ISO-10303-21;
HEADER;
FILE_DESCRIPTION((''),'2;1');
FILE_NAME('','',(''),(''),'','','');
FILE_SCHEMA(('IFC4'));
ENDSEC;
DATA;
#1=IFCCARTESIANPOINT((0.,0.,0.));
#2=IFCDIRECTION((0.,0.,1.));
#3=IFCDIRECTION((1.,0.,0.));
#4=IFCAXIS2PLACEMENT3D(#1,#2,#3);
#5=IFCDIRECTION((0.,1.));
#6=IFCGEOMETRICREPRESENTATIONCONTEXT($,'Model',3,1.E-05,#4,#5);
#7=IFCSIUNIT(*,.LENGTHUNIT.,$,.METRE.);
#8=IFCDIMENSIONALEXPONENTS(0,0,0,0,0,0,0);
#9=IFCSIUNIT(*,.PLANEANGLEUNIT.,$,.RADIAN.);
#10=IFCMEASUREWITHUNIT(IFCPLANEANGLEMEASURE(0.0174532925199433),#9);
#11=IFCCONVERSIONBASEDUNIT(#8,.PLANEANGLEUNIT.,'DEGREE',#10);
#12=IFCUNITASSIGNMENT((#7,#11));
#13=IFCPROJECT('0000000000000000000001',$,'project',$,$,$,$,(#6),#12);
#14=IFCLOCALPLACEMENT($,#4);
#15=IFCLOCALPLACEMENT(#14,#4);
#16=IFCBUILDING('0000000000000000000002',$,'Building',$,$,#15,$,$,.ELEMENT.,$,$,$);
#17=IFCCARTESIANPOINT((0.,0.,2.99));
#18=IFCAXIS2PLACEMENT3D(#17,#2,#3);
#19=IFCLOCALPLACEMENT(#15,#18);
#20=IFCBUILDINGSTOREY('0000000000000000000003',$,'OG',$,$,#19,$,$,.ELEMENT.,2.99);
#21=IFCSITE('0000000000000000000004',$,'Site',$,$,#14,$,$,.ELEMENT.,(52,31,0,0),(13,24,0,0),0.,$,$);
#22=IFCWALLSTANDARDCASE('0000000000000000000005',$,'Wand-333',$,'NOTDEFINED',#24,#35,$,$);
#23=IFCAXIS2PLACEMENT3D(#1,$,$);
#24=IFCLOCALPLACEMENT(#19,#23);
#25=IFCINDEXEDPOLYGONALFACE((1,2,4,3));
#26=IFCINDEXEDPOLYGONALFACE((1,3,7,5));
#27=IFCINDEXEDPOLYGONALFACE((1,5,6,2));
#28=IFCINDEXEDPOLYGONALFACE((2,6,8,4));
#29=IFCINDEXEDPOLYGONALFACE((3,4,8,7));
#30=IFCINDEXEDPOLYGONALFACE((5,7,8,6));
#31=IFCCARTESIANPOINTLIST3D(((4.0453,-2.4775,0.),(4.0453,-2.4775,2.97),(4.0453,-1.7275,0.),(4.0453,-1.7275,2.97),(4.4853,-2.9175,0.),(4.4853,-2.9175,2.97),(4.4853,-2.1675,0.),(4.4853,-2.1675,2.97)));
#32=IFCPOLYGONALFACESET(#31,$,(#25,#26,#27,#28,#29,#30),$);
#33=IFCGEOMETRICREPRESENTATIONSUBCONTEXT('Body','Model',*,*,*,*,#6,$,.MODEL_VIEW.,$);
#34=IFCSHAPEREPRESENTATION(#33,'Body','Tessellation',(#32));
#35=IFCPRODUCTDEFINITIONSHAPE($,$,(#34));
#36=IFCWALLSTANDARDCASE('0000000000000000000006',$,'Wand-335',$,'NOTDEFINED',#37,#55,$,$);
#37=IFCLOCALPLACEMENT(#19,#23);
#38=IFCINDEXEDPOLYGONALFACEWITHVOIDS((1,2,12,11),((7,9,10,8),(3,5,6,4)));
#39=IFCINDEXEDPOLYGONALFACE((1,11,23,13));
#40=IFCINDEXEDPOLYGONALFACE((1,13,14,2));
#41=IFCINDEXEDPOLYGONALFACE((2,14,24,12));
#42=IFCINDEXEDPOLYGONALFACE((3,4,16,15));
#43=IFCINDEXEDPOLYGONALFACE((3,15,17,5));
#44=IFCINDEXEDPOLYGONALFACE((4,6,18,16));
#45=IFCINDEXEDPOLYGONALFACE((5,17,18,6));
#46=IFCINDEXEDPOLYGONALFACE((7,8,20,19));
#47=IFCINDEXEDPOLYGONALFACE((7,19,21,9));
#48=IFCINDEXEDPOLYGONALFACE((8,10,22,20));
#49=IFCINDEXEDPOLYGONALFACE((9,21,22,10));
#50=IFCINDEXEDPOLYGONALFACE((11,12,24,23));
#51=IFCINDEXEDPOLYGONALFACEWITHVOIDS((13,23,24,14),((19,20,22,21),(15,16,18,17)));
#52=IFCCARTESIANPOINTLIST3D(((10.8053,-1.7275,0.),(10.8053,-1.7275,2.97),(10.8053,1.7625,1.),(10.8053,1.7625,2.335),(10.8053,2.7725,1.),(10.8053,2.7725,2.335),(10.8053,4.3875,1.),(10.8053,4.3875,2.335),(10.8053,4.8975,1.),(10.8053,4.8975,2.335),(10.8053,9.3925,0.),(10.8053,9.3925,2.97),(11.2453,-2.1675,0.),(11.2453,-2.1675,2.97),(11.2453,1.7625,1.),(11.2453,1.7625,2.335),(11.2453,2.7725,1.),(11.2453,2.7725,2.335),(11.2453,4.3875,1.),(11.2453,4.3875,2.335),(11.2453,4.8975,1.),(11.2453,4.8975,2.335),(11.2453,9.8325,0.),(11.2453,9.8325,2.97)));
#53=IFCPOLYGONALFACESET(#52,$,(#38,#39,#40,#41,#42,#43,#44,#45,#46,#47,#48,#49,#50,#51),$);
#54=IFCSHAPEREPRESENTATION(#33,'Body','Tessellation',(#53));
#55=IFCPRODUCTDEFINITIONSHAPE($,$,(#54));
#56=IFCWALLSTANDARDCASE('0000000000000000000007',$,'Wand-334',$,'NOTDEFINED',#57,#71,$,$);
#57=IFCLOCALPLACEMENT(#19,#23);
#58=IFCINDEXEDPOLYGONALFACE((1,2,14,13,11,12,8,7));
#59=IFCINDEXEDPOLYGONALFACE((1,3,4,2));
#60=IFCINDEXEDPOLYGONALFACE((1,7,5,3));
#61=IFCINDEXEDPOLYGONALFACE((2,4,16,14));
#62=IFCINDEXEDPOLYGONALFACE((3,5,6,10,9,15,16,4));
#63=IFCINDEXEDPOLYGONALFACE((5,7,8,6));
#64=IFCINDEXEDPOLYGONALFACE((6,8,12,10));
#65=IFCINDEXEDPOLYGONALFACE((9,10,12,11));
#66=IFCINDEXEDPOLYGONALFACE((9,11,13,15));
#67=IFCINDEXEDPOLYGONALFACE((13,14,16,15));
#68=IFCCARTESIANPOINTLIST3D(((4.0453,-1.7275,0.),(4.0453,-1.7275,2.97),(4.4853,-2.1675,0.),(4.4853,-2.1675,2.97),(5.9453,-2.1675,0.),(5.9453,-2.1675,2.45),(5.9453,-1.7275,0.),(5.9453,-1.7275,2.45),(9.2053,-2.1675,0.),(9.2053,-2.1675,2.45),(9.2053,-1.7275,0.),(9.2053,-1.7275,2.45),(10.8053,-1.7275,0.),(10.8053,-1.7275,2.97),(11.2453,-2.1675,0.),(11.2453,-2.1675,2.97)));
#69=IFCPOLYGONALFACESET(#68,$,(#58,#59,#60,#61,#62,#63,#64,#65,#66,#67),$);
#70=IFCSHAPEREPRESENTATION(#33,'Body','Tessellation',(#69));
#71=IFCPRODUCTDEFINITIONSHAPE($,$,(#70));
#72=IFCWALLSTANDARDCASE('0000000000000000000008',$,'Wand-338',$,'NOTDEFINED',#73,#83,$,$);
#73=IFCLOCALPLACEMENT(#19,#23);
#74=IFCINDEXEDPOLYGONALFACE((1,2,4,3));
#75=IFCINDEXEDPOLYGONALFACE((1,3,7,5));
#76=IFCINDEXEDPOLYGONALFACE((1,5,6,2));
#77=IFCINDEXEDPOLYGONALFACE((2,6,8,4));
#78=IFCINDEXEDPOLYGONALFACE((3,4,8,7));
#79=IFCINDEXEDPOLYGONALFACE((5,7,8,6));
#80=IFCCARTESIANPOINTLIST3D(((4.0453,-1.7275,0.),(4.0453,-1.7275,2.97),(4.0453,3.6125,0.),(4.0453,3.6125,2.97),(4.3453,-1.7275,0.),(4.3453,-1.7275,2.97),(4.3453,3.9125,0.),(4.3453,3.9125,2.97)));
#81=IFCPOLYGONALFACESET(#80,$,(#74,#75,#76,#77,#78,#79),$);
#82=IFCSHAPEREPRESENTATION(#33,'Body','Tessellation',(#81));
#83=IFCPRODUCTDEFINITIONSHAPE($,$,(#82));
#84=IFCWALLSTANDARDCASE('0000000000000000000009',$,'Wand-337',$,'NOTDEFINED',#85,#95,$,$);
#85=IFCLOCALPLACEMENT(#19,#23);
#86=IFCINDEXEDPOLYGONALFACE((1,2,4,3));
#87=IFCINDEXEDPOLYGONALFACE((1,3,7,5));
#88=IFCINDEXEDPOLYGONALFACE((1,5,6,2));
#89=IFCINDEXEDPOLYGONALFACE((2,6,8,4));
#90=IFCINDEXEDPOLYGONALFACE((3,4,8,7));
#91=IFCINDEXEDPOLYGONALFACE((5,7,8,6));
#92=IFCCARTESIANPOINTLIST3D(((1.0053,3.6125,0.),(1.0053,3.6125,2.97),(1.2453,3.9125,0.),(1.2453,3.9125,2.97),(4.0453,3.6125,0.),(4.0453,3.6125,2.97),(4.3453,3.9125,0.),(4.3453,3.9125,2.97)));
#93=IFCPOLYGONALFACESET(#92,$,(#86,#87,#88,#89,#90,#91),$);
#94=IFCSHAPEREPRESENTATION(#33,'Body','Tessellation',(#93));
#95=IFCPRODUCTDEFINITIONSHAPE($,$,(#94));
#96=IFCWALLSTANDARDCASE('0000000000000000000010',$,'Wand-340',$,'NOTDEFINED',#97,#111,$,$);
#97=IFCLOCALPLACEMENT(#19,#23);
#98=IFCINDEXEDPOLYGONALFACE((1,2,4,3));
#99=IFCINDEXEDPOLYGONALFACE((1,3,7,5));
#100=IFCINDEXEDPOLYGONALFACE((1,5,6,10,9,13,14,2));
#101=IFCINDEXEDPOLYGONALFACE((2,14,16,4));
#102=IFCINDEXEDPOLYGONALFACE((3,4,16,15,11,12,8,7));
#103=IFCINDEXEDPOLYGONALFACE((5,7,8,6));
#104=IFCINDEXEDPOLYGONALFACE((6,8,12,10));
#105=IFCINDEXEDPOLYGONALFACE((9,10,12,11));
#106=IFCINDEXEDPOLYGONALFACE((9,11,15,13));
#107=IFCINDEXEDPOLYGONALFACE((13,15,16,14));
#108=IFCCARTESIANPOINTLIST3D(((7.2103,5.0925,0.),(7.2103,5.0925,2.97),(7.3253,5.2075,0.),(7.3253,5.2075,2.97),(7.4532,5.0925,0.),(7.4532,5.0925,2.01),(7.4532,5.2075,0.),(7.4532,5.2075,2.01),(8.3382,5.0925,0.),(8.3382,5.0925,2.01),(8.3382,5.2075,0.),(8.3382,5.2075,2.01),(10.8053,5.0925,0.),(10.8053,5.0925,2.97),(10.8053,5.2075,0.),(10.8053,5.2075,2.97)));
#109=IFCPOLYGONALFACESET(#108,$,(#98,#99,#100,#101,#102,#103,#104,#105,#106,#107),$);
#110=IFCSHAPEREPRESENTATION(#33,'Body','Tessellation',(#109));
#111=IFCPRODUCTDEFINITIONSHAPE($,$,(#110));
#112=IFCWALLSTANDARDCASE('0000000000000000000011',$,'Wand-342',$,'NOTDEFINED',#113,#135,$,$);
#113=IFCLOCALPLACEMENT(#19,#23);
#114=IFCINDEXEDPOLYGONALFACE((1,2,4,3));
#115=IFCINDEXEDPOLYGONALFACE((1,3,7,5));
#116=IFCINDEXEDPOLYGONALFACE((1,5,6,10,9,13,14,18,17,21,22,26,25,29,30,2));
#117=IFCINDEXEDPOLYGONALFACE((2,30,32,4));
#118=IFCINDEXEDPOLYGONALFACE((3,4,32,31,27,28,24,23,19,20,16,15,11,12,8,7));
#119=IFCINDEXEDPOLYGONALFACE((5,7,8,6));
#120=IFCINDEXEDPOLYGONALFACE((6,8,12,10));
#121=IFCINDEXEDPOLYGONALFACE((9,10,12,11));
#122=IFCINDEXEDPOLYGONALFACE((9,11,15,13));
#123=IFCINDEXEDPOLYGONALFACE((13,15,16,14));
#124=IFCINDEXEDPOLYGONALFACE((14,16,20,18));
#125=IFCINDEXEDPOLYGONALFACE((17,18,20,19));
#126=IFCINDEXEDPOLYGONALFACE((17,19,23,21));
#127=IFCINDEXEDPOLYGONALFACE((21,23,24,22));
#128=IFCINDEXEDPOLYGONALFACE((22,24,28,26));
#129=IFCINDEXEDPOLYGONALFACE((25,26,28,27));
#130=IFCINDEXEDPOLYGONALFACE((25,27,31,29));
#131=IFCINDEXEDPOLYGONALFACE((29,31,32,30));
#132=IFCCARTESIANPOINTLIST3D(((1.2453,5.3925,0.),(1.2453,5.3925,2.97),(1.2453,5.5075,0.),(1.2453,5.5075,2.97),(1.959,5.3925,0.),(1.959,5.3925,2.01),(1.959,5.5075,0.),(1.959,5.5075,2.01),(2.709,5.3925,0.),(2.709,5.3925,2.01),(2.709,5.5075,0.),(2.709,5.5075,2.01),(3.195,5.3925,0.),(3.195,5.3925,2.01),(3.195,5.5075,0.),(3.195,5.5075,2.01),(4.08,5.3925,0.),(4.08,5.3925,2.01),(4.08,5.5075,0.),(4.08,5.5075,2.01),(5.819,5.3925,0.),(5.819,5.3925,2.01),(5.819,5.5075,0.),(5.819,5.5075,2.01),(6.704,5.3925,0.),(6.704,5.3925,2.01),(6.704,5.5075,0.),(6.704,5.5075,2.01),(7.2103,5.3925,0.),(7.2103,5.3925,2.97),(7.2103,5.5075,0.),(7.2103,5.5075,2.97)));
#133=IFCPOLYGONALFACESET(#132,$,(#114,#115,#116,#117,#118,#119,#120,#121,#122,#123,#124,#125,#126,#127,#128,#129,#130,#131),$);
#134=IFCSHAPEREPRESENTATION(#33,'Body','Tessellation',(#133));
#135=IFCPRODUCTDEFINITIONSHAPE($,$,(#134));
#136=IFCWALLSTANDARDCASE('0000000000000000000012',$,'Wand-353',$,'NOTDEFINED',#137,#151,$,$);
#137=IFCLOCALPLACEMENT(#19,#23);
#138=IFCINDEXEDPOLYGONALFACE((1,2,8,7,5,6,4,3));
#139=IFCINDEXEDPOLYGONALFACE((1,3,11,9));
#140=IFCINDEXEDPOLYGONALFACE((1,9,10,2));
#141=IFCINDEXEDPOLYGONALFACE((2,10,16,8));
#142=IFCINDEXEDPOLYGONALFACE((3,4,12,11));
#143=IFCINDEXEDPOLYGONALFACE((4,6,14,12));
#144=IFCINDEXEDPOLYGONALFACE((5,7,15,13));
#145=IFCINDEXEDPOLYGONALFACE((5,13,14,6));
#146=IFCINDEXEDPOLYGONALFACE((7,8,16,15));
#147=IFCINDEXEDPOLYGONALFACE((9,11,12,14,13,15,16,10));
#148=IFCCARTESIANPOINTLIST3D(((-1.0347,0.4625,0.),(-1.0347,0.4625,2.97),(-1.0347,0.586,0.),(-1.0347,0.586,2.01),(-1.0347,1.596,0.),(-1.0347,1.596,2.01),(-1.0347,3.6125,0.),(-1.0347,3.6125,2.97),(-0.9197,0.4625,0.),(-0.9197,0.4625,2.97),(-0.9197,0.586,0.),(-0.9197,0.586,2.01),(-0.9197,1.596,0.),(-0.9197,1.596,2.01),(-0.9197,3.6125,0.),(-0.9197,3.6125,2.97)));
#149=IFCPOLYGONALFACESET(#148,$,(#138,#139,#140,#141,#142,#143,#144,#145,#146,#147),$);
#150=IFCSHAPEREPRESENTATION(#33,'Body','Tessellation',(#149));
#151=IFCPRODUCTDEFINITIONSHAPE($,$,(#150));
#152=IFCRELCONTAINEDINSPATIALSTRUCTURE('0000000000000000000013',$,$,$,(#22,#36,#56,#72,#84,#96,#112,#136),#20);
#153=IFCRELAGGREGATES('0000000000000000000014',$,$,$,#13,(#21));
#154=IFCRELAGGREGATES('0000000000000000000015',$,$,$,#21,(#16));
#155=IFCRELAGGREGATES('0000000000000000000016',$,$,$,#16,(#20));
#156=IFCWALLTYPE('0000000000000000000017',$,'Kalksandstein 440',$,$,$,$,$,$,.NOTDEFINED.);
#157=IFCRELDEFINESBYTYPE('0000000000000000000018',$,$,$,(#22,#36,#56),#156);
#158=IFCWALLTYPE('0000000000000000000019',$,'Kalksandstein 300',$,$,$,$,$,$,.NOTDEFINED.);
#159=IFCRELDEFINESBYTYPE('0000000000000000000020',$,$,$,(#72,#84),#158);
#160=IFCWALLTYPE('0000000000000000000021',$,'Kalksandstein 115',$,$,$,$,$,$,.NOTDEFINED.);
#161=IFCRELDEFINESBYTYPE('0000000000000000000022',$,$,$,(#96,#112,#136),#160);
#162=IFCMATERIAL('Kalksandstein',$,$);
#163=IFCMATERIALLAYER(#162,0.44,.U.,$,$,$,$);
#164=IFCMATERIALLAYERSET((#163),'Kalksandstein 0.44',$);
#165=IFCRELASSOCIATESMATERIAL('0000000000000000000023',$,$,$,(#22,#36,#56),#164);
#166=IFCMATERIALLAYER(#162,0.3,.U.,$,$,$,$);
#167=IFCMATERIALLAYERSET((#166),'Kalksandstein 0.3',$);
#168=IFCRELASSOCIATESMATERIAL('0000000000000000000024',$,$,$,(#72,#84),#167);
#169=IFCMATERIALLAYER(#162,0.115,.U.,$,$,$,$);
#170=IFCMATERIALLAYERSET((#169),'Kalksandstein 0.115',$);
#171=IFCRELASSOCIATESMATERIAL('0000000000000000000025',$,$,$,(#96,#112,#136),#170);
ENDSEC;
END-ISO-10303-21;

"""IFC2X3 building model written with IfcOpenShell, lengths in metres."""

from ifc_helpers import new_model, entity, si_unit, converted_unit, direction, frame, origin_with_axes, origin_2d_with_axis, place, context, subcontext, project, spatial, polyline, rectangle, outline, extrude, material, layer, layer_set, layer_usage, type_object, element, save


model = new_model("IFC2X3")

# Units and contexts
model_context = context("Model", 3, precision=1e-05, world=origin_with_axes(), true_north=direction((0.0, 1.0)))
body_context = subcontext(model_context, "Body", "Model", "MODEL_VIEW")
ifc_project = project(units=[si_unit("LENGTHUNIT", "METRE"), converted_unit("PLANEANGLEUNIT", "DEGREE", entity("IfcPlaneAngleMeasure", 0.0174532925199433), si_unit("PLANEANGLEUNIT", "RADIAN"), dimensions=[0, 0, 0, 0, 0, 0, 0])], contexts=[model_context])

# Site, building, storey
site_placement = place(None, origin_with_axes())
site = spatial("IfcSite", under=ifc_project, at=site_placement, Name="Site", CompositionType="ELEMENT", RefLatitude=(52, 31, 0, 0), RefLongitude=(13, 24, 0, 0), RefElevation=0.0)
building_placement = place(site_placement, origin_with_axes())
building = spatial("IfcBuilding", under=site, at=building_placement, Name="Building", CompositionType="ELEMENT")
storey_placement = place(building_placement, frame((0.0, 0.0, 2.99), z_axis=(0.0, 0.0, 1.0), x_axis=(1.0, 0.0, 0.0)))
storey = spatial("IfcBuildingStorey", under=building, at=storey_placement, Name="OG", CompositionType="ELEMENT", Elevation=2.99)

# Shared definitions
ifc_material = material(Name="Kalksandstein")
ifc_layer_1 = layer(ifc_material, 0.44, ventilated="UNKNOWN")
ifc_layer_set_1 = layer_set([ifc_layer_1], Name="Kalksandstein 0.44")
wall_type_1 = type_object("IfcWallType", Name="Kalksandstein 440", PredefinedType="NOTDEFINED")

# Wall
ifc_layer_usage_1 = layer_usage(ifc_layer_set_1, "AXIS2", "NEGATIVE", 0.44)
wall_1_placement = place(storey_placement, frame((4.4853, -2.9175, 0.0), z_axis=(0.0, 0.0, 1.0), x_axis=(0.0, 1.0, 0.0)))
element("IfcWallStandardCase", 1, at=wall_1_placement, inside=storey, type_object=wall_type_1, material=ifc_layer_usage_1, Name="Wand-333", ObjectType="NOTDEFINED", context=body_context, shape_type="SweptSolid", body=[
    extrude(outline(polyline([(0.0, 0.0), (0.75, 0.0), (1.19, 0.44), (0.44, 0.44), (0.0, 0.0)])), origin_with_axes(), (0.0, 0.0, 1.0), 2.97),
])

# Wall, openings
ifc_layer_usage_2 = layer_usage(ifc_layer_set_1, "AXIS2", "NEGATIVE", 0.44)
wall_2_placement = place(storey_placement, frame((11.2453, -2.1675, 0.0), z_axis=(0.0, 0.0, 1.0), x_axis=(0.0, 1.0, 0.0)))
wall_2 = element("IfcWallStandardCase", 2, at=wall_2_placement, inside=storey, type_object=wall_type_1, material=ifc_layer_usage_2, Name="Wand-335", ObjectType="NOTDEFINED", context=body_context, shape_type="SweptSolid", body=[
    extrude(outline(polyline([(0.0, 0.0), (12.0, 0.0), (11.56, 0.44), (0.44, 0.44), (0.0, 0.0)])), origin_with_axes(), (0.0, 0.0, 1.0), 2.97),
])
opening_1_placement = place(wall_2_placement, frame((4.435, 0.0, 1.0), z_axis=(0.0, 0.0, 1.0), x_axis=(1.0, 0.0, 0.0)))
element("IfcOpeningElement", 3, at=opening_1_placement, cuts=wall_2, context=body_context, shape_type="SweptSolid", body=[
    extrude(rectangle(XDim=1.01, YDim=1.335, at=origin_2d_with_axis()), frame((0.0, 0.44, 0.6675), z_axis=(0.0, -1.0, 0.0), x_axis=(-1.0, 0.0, 0.0)), (0.0, 0.0, 1.0), 1.32),
])
opening_2_placement = place(wall_2_placement, frame((6.81, 0.0, 1.0), z_axis=(0.0, 0.0, 1.0), x_axis=(1.0, 0.0, 0.0)))
element("IfcOpeningElement", 4, at=opening_2_placement, cuts=wall_2, context=body_context, shape_type="SweptSolid", body=[
    extrude(rectangle(XDim=0.51, YDim=1.335, at=origin_2d_with_axis()), frame((0.0, 0.44, 0.6675), z_axis=(0.0, -1.0, 0.0), x_axis=(-1.0, 0.0, 0.0)), (0.0, 0.0, 1.0), 1.32),
])

# Wall, opening
ifc_layer_usage_3 = layer_usage(ifc_layer_set_1, "AXIS2", "NEGATIVE", 0.44)
wall_3_placement = place(storey_placement, frame((4.4853, -2.1675, 0.0), z_axis=(0.0, 0.0, 1.0), x_axis=(1.0, 0.0, 0.0)))
wall_3 = element("IfcWallStandardCase", 5, at=wall_3_placement, inside=storey, type_object=wall_type_1, material=ifc_layer_usage_3, Name="Wand-334", ObjectType="NOTDEFINED", context=body_context, shape_type="SweptSolid", body=[
    extrude(outline(polyline([(0.0, 0.0), (6.76, 0.0), (6.32, 0.44), (-0.44, 0.44), (0.0, 0.0)])), origin_with_axes(), (0.0, 0.0, 1.0), 2.97),
])
opening_3_placement = place(wall_3_placement, frame((3.09, 0.0, 0.0), z_axis=(0.0, 0.0, 1.0), x_axis=(1.0, 0.0, 0.0)))
element("IfcOpeningElement", 6, at=opening_3_placement, cuts=wall_3, context=body_context, shape_type="SweptSolid", body=[
    extrude(rectangle(XDim=3.26, YDim=2.45, at=origin_2d_with_axis()), frame((0.0, 0.44, 1.225), z_axis=(0.0, -1.0, 0.0), x_axis=(-1.0, 0.0, 0.0)), (0.0, 0.0, 1.0), 1.32),
])

# Walls
ifc_layer_2 = layer(ifc_material, 0.3, ventilated="UNKNOWN")
ifc_layer_set_2 = layer_set([ifc_layer_2], Name="Kalksandstein 0.3")
ifc_layer_usage_4 = layer_usage(ifc_layer_set_2, "AXIS2", "NEGATIVE", 0.3)
wall_type_2 = type_object("IfcWallType", Name="Kalksandstein 300", PredefinedType="NOTDEFINED")
wall_4_placement = place(storey_placement, frame((4.0453, 3.6125, 0.0), z_axis=(0.0, 0.0, 1.0), x_axis=(0.0, -1.0, 0.0)))
element("IfcWallStandardCase", 7, at=wall_4_placement, inside=storey, type_object=wall_type_2, material=ifc_layer_usage_4, Name="Wand-338", ObjectType="NOTDEFINED", context=body_context, shape_type="SweptSolid", body=[
    extrude(outline(polyline([(0.0, 0.0), (5.34, 0.0), (5.34, 0.3), (-0.3, 0.3), (0.0, 0.0)])), origin_with_axes(), (0.0, 0.0, 1.0), 2.97),
])
ifc_layer_usage_5 = layer_usage(ifc_layer_set_2, "AXIS2", "NEGATIVE", 0.3)
wall_5_placement = place(storey_placement, frame((1.2453, 3.6125, 0.0), z_axis=(0.0, 0.0, 1.0), x_axis=(1.0, 0.0, 0.0)))
element("IfcWallStandardCase", 8, at=wall_5_placement, inside=storey, type_object=wall_type_2, material=ifc_layer_usage_5, Name="Wand-337", ObjectType="NOTDEFINED", context=body_context, shape_type="SweptSolid", body=[
    extrude(outline(polyline([(-0.24, 0.0), (2.8, 0.0), (3.1, 0.3), (0.0, 0.3), (-0.24, 0.0)])), origin_with_axes(), (0.0, 0.0, 1.0), 2.97),
])

# Wall, opening
ifc_layer_3 = layer(ifc_material, 0.115, ventilated="UNKNOWN")
ifc_layer_set_3 = layer_set([ifc_layer_3], Name="Kalksandstein 0.115")
ifc_layer_usage_6 = layer_usage(ifc_layer_set_3, "AXIS2", "POSITIVE", -0.115)
wall_type_3 = type_object("IfcWallType", Name="Kalksandstein 115", PredefinedType="NOTDEFINED")
wall_6_placement = place(storey_placement, frame((7.3253, 5.2075, 0.0), z_axis=(0.0, 0.0, 1.0), x_axis=(1.0, 0.0, 0.0)))
wall_6 = element("IfcWallStandardCase", 9, at=wall_6_placement, inside=storey, type_object=wall_type_3, material=ifc_layer_usage_6, Name="Wand-340", ObjectType="NOTDEFINED", context=body_context, shape_type="SweptSolid", body=[
    extrude(outline(polyline([(-0.115, -0.115), (3.48, -0.115), (3.48, 0.0), (0.0, 0.0), (-0.115, -0.115)])), origin_with_axes(), (0.0, 0.0, 1.0), 2.97),
])
opening_4_placement = place(wall_6_placement, frame((0.5705, 0.0, 0.0), z_axis=(0.0, 0.0, 1.0), x_axis=(1.0, 0.0, 0.0)))
element("IfcOpeningElement", 10, at=opening_4_placement, cuts=wall_6, context=body_context, shape_type="SweptSolid", body=[
    extrude(rectangle(XDim=0.885, YDim=2.01, at=origin_2d_with_axis()), frame((0.0, -0.115, 1.005), z_axis=(0.0, -1.0, 0.0), x_axis=(-1.0, 0.0, 0.0)), (0.0, 0.0, -1.0), 0.345),
])

# Wall, openings
ifc_layer_usage_7 = layer_usage(ifc_layer_set_3, "AXIS2", "POSITIVE", -0.115)
wall_7_placement = place(storey_placement, frame((1.2453, 5.5075, 0.0), z_axis=(0.0, 0.0, 1.0), x_axis=(1.0, 0.0, 0.0)))
wall_7 = element("IfcWallStandardCase", 11, at=wall_7_placement, inside=storey, type_object=wall_type_3, material=ifc_layer_usage_7, Name="Wand-342", ObjectType="NOTDEFINED", context=body_context, shape_type="SweptSolid", body=[
    extrude(outline(polyline([(0.0, -0.115), (5.965, -0.115), (5.965, 0.0), (0.0, 0.0), (0.0, -0.115)])), origin_with_axes(), (0.0, 0.0, 1.0), 2.97),
])
opening_5_placement = place(wall_7_placement, frame((1.0887, 0.0, 0.0), z_axis=(0.0, 0.0, 1.0), x_axis=(1.0, 0.0, 0.0)))
element("IfcOpeningElement", 12, at=opening_5_placement, cuts=wall_7, context=body_context, shape_type="SweptSolid", body=[
    extrude(rectangle(XDim=0.75, YDim=2.01, at=origin_2d_with_axis()), frame((0.0, 0.115, 1.005), z_axis=(0.0, -1.0, 0.0), x_axis=(-1.0, 0.0, 0.0)), (0.0, 0.0, 1.0), 0.345),
])
opening_6_placement = place(wall_7_placement, frame((5.0163, 0.0, 0.0), z_axis=(0.0, 0.0, 1.0), x_axis=(1.0, 0.0, 0.0)))
element("IfcOpeningElement", 13, at=opening_6_placement, cuts=wall_7, context=body_context, shape_type="SweptSolid", body=[
    extrude(rectangle(XDim=0.885, YDim=2.01, at=origin_2d_with_axis()), frame((0.0, -0.115, 1.005), z_axis=(0.0, 1.0, 0.0), x_axis=(1.0, 0.0, 0.0)), (0.0, 0.0, 1.0), 0.345),
])
opening_7_placement = place(wall_7_placement, frame((2.3922, 0.0, 0.0), z_axis=(0.0, 0.0, 1.0), x_axis=(1.0, 0.0, 0.0)))
element("IfcOpeningElement", 14, at=opening_7_placement, cuts=wall_7, context=body_context, shape_type="SweptSolid", body=[
    extrude(rectangle(XDim=0.885, YDim=2.01, at=origin_2d_with_axis()), frame((0.0, -0.115, 1.005), z_axis=(0.0, 1.0, 0.0), x_axis=(1.0, 0.0, 0.0)), (0.0, 0.0, 1.0), 0.345),
])

# Wall, opening
ifc_layer_usage_8 = layer_usage(ifc_layer_set_3, "AXIS2", "POSITIVE", -0.115)
wall_8_placement = place(storey_placement, frame((-1.0347, 0.4625, 0.0), z_axis=(0.0, 0.0, 1.0), x_axis=(0.0, 1.0, 0.0)))
wall_8 = element("IfcWallStandardCase", 15, at=wall_8_placement, inside=storey, type_object=wall_type_3, material=ifc_layer_usage_8, Name="Wand-353", ObjectType="NOTDEFINED", context=body_context, shape_type="SweptSolid", body=[
    extrude(outline(polyline([(0.0, -0.115), (3.15, -0.115), (3.15, 0.0), (0.0, 0.0), (0.0, -0.115)])), origin_with_axes(), (0.0, 0.0, 1.0), 2.97),
])
opening_8_placement = place(wall_8_placement, frame((0.6285, 0.0, 0.0), z_axis=(0.0, 0.0, 1.0), x_axis=(1.0, 0.0, 0.0)))
element("IfcOpeningElement", 16, at=opening_8_placement, cuts=wall_8, context=body_context, shape_type="SweptSolid", body=[
    extrude(rectangle(XDim=1.01, YDim=2.01, at=origin_2d_with_axis()), frame((0.0, -0.115, 1.005), z_axis=(0.0, -1.0, 0.0), x_axis=(-1.0, 0.0, 0.0)), (0.0, 0.0, -1.0), 0.345),
])

save(model, "model.ifc")
